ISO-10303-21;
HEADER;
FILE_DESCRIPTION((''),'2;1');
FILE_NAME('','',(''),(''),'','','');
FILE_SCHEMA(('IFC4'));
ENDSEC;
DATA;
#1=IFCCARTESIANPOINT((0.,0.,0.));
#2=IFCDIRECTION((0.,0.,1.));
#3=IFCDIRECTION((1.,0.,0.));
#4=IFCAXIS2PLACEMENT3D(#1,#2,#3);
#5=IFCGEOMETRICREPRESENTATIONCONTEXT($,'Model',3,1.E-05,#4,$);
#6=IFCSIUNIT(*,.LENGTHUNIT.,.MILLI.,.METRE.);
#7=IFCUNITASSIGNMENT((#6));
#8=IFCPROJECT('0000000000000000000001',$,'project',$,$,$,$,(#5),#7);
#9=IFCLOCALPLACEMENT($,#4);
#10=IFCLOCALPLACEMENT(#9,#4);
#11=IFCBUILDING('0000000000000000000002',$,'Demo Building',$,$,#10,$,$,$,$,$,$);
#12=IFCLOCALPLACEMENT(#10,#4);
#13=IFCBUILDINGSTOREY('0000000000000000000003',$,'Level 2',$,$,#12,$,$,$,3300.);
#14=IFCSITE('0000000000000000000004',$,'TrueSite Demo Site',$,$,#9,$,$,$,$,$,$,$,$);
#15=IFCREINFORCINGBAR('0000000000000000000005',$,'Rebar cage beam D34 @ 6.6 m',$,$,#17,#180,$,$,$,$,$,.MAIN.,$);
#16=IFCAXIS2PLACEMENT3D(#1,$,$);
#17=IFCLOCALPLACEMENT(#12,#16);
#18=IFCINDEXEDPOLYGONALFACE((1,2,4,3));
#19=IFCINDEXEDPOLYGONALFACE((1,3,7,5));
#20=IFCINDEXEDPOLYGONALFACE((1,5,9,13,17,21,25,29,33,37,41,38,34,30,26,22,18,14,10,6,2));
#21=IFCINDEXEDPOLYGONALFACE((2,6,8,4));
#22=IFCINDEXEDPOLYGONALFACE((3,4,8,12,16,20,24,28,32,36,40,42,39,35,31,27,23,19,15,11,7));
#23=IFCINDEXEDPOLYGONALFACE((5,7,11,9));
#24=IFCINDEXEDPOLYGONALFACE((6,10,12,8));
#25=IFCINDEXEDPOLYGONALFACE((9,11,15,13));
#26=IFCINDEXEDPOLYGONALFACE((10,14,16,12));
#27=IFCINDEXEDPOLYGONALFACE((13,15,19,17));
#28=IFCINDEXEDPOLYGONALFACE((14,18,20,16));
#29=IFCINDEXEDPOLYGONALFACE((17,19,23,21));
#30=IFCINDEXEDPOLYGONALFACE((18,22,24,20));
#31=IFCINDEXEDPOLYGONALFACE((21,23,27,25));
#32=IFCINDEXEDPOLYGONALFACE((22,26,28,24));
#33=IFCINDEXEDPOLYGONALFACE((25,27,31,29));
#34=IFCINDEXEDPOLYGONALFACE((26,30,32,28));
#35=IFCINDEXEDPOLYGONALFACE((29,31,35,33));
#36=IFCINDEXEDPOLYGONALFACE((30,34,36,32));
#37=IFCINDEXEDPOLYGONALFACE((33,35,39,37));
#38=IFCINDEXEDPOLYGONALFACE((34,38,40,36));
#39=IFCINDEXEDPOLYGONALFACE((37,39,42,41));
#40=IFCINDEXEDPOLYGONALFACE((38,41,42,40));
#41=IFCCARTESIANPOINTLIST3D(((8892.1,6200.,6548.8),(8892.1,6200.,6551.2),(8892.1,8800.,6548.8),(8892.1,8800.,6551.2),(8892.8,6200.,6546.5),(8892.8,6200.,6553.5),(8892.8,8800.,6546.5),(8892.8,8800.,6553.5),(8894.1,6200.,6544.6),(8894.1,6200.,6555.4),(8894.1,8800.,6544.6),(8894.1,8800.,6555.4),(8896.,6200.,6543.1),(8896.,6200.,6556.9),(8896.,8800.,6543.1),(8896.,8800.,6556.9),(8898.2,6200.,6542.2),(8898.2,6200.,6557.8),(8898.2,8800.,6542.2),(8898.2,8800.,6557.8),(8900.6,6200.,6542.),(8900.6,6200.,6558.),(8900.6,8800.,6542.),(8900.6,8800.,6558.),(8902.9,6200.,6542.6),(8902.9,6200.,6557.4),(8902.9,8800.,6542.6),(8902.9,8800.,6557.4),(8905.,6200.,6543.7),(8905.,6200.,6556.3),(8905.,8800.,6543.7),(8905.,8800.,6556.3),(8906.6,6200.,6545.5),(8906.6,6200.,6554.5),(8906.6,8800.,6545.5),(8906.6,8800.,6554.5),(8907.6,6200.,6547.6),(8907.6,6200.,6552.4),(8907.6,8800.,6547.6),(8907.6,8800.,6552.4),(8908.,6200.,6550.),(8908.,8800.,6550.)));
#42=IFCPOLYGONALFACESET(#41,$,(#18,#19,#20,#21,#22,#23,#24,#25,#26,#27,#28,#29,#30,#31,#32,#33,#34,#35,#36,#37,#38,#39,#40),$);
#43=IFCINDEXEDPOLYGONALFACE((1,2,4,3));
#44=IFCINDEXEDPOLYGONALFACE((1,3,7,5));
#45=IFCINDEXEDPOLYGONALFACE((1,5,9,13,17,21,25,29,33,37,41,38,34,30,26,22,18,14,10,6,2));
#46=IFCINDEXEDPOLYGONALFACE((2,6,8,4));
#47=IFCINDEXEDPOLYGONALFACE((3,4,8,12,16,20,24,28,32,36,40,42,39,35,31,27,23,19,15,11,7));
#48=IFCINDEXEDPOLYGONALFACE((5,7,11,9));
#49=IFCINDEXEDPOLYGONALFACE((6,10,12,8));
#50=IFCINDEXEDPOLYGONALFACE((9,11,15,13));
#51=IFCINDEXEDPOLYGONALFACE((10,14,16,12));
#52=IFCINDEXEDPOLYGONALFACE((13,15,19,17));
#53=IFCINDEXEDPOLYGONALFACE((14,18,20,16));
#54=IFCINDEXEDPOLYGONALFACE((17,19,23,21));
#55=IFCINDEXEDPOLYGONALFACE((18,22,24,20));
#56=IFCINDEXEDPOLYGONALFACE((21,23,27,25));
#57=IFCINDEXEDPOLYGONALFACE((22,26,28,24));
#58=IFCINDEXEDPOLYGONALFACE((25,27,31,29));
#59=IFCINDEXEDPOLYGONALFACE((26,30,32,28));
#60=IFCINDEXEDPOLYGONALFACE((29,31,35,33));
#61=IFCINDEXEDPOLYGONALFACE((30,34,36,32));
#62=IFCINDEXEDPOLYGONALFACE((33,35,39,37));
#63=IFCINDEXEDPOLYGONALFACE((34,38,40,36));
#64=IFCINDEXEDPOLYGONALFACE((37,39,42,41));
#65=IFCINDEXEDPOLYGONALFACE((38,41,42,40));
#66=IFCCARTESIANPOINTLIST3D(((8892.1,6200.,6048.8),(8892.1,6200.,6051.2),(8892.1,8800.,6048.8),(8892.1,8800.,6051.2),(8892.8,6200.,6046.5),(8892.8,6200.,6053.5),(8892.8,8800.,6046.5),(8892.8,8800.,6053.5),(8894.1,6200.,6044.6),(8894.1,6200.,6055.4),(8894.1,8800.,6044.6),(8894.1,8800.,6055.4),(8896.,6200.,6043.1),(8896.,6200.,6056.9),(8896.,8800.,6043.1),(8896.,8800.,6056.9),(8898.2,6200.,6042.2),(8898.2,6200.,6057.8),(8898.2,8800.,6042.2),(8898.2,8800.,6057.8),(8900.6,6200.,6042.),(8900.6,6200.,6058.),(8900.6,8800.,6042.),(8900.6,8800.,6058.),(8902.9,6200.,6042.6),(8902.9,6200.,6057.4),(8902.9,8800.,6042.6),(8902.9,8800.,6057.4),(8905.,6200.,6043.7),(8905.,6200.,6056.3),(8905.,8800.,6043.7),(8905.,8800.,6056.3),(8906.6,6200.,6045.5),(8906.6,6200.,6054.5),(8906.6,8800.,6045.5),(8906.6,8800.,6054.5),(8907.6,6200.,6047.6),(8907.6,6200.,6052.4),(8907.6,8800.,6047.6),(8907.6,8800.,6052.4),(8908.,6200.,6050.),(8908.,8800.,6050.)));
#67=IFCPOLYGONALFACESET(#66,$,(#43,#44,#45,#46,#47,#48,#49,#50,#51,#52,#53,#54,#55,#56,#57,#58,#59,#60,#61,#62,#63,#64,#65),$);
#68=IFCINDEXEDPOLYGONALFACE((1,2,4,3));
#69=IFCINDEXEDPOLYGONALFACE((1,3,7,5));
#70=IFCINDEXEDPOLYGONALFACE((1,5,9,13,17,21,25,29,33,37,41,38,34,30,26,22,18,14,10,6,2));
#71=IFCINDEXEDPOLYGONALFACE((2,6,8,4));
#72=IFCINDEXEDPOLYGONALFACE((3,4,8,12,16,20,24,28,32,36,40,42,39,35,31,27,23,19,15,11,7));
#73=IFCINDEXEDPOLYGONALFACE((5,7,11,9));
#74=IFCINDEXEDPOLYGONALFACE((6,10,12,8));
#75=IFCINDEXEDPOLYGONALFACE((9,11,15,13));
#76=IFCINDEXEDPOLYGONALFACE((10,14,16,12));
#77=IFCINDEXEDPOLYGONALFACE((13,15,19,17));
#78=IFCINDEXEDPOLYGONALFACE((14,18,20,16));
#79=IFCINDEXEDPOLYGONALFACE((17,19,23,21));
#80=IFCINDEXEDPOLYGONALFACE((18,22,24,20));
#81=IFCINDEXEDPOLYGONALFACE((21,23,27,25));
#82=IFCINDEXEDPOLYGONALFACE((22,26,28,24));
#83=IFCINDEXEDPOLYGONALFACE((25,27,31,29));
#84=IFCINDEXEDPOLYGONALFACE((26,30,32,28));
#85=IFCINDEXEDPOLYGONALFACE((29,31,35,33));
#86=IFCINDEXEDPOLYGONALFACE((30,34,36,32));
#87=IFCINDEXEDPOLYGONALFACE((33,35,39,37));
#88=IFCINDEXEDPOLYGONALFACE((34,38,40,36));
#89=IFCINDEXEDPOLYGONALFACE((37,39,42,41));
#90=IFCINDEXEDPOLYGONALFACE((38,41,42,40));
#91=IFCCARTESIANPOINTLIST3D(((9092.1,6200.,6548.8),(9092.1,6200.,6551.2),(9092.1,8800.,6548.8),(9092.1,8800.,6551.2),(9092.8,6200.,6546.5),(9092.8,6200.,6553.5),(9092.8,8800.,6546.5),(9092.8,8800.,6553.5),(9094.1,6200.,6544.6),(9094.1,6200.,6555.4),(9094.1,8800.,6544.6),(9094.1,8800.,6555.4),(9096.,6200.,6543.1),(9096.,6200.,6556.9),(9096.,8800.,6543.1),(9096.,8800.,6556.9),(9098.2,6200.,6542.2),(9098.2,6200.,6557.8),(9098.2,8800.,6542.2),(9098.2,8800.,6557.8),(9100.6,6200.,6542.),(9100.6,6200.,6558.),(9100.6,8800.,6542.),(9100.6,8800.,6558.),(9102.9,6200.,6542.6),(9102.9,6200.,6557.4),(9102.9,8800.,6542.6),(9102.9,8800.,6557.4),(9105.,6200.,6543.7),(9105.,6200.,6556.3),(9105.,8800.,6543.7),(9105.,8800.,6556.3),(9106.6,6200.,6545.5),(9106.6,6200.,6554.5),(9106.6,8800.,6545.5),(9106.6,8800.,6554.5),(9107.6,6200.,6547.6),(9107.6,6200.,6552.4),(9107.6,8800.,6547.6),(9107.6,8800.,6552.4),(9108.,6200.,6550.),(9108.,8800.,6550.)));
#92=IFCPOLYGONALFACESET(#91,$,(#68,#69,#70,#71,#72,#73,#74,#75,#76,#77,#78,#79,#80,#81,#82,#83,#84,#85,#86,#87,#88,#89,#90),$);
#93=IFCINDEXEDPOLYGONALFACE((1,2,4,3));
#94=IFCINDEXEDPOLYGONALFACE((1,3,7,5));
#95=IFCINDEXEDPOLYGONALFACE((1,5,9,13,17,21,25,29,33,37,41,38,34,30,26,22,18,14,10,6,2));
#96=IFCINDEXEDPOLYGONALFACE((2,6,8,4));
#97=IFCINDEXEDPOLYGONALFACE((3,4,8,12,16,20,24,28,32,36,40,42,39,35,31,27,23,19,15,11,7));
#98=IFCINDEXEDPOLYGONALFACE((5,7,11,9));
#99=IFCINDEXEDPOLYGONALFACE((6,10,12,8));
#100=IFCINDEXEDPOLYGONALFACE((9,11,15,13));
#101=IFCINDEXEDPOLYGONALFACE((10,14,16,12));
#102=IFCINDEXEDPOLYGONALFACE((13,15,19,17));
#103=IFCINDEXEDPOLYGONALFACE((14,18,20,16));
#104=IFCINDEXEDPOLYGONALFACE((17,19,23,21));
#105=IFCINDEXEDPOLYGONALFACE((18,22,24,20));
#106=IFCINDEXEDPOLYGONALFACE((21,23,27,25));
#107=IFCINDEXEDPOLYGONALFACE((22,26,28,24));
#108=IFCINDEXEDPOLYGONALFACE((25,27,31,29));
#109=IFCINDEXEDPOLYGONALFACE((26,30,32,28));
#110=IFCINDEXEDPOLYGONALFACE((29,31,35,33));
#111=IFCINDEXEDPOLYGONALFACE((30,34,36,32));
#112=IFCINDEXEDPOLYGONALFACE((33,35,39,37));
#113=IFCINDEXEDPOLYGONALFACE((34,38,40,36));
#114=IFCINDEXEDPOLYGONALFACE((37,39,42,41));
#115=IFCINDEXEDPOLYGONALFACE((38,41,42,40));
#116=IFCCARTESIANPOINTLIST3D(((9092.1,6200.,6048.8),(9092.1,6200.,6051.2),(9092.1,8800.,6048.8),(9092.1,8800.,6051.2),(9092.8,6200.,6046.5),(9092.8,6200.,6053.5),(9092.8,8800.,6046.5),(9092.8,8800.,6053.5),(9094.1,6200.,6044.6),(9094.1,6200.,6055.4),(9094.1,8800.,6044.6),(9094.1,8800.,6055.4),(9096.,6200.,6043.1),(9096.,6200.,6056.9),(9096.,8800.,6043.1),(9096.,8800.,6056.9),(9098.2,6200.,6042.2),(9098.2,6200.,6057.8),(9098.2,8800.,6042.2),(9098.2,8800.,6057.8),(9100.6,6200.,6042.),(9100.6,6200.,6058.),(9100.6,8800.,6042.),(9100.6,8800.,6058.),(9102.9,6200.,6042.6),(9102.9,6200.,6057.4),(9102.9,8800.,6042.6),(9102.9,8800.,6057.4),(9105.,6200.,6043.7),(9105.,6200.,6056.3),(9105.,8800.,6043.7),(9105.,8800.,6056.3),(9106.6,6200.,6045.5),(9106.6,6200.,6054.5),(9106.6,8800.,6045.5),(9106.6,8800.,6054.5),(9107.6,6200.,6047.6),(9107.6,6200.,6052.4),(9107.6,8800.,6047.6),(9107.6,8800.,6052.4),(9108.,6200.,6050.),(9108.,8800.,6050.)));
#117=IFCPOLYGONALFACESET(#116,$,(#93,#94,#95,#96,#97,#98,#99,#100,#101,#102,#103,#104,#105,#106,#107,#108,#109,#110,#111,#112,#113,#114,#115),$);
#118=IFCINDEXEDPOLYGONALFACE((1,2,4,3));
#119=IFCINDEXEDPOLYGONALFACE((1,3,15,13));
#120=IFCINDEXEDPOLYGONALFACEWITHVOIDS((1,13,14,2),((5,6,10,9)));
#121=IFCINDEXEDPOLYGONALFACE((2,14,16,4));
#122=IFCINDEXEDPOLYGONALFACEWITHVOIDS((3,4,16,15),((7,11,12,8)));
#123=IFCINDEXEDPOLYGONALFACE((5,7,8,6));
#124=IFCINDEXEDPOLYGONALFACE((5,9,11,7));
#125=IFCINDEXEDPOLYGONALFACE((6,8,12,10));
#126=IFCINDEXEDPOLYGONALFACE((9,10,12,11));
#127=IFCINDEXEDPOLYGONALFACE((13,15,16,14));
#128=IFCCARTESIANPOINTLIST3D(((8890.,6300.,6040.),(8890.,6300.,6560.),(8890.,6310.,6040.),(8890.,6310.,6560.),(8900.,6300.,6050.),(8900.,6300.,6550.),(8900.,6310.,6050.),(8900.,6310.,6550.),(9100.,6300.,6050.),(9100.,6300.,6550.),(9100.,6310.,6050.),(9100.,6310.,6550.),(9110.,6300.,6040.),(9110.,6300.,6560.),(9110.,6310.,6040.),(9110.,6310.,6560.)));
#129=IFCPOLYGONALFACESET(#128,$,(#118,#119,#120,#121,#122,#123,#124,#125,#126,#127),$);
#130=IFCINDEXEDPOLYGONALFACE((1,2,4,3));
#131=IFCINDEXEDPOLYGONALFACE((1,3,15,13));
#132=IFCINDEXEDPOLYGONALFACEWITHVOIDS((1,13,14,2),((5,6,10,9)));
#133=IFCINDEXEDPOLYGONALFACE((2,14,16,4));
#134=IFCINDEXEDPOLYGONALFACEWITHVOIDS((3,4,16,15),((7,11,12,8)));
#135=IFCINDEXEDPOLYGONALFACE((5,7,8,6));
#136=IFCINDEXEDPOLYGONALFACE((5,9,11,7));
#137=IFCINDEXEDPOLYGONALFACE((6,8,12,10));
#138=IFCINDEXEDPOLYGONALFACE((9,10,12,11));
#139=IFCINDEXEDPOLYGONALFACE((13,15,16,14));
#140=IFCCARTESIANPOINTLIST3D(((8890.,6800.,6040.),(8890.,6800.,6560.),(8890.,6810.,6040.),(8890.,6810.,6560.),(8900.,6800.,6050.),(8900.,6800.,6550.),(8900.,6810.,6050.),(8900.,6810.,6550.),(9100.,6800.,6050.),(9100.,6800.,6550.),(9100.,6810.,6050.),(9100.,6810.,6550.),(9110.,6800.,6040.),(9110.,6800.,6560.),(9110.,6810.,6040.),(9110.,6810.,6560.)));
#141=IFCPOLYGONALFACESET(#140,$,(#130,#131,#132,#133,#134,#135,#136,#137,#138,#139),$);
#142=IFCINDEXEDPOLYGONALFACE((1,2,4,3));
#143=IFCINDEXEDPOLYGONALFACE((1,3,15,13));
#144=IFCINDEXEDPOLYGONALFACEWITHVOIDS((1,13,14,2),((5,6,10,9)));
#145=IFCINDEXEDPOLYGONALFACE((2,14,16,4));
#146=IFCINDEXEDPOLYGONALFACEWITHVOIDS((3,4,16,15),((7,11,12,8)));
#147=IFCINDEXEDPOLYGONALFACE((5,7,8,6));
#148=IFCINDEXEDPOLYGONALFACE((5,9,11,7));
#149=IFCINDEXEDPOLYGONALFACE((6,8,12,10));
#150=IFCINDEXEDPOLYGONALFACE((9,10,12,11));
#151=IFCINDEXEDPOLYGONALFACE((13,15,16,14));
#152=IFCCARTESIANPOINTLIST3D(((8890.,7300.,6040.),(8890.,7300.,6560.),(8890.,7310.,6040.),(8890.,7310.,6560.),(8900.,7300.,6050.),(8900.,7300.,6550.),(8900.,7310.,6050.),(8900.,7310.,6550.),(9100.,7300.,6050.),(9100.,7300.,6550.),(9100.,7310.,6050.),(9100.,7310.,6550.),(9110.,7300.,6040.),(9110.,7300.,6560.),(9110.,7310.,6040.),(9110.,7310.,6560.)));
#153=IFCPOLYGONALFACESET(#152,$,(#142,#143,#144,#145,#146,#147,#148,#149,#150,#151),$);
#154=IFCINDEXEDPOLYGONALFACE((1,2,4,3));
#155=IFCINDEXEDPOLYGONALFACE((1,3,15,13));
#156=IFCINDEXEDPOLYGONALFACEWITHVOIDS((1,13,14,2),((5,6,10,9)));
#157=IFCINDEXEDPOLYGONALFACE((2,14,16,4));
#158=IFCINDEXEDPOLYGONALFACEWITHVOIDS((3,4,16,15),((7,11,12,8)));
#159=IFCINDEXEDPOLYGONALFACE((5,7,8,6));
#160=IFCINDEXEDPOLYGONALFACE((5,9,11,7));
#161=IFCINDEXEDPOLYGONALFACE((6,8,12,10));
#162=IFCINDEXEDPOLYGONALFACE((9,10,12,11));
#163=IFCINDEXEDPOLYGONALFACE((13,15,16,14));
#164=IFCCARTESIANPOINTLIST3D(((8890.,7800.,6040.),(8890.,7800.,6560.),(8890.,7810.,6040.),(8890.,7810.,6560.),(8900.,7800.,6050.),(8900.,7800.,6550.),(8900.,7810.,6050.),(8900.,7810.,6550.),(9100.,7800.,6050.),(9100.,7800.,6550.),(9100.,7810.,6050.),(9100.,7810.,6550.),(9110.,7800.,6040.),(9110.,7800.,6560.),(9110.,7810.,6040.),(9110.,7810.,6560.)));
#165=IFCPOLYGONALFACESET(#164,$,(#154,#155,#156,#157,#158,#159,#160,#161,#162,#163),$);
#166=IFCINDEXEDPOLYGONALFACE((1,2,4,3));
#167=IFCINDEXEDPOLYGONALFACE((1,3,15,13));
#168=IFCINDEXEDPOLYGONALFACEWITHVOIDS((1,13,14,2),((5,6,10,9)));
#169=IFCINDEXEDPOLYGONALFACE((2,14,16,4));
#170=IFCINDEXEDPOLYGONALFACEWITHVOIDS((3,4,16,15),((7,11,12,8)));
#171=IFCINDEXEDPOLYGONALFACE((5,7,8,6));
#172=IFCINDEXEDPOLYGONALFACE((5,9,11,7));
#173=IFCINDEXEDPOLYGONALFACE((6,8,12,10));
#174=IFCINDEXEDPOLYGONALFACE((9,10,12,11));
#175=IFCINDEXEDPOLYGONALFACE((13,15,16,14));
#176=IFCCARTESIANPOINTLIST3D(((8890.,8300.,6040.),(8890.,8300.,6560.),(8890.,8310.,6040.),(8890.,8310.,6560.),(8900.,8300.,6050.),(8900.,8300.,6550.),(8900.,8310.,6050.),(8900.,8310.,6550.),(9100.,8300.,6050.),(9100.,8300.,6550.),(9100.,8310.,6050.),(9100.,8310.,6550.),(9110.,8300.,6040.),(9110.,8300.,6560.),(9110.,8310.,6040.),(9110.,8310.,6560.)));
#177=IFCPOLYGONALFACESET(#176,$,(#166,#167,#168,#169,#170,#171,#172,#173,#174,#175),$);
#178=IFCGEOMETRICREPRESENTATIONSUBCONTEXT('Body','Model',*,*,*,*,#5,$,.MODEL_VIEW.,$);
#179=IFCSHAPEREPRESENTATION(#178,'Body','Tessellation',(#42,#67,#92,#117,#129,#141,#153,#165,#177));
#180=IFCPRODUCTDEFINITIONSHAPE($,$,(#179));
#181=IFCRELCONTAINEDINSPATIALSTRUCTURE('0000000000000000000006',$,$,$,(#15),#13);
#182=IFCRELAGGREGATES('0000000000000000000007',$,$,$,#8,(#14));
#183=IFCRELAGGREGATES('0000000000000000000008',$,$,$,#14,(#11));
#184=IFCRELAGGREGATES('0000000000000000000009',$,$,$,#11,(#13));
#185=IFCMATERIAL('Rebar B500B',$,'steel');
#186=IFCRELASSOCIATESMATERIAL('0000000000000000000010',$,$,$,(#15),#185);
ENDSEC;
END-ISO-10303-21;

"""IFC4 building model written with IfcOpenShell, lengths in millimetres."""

from ifc_helpers import new_model, si_unit, frame, origin_with_axes, place, context, subcontext, project, spatial, hollow_rectangle, circle, extrude, material, element, save


model = new_model("IFC4")

# Units and contexts
model_context = context("Model", 3, precision=1e-05, world=origin_with_axes())
body_context = subcontext(model_context, "Body", "Model", "MODEL_VIEW")
ifc_project = project(units=[si_unit("LENGTHUNIT", "METRE", prefix="MILLI")], contexts=[model_context])

# Site, building, storey
site_placement = place(None, origin_with_axes())
site = spatial("IfcSite", under=ifc_project, at=site_placement, Name="TrueSite Demo Site")
building_placement = place(site_placement, origin_with_axes())
building = spatial("IfcBuilding", under=site, at=building_placement, Name="Demo Building")
storey_placement = place(building_placement, origin_with_axes())
storey = spatial("IfcBuildingStorey", under=building, at=storey_placement, Name="Level 2", Elevation=3300.0)

# Reinforcing bar
ifc_material_1 = material(Name="Rebar B500B", Category="steel")
for number, where, z_axis, x_axis, name in (
    (1, (9000.0, 6200.0, 6300.0), (0.0, 1.0, 0.0), (1.0, 0.0, 0.0), "Rebar cage beam D34 @ 6.6 m"),
):
    element("IfcReinforcingBar", number, at=place(storey_placement, frame(where, z_axis=z_axis, x_axis=x_axis)), inside=storey, material=ifc_material_1, Name=name, PredefinedType="MAIN", context=body_context, shape_type="SweptSolid", body=[
        extrude(circle(Radius=8.0), frame((-100.0, -250.0, 0.0)), (0.0, 0.0, 1.0), 2600.0),
        extrude(circle(Radius=8.0), frame((-100.0, 250.0, 0.0)), (0.0, 0.0, 1.0), 2600.0),
        extrude(circle(Radius=8.0), frame((100.0, -250.0, 0.0)), (0.0, 0.0, 1.0), 2600.0),
        extrude(circle(Radius=8.0), frame((100.0, 250.0, 0.0)), (0.0, 0.0, 1.0), 2600.0),
        extrude(hollow_rectangle(XDim=220.0, YDim=520.0, WallThickness=10.0), frame((0.0, 0.0, 100.0)), (0.0, 0.0, 1.0), 10.0),
        extrude(hollow_rectangle(XDim=220.0, YDim=520.0, WallThickness=10.0), frame((0.0, 0.0, 600.0)), (0.0, 0.0, 1.0), 10.0),
        extrude(hollow_rectangle(XDim=220.0, YDim=520.0, WallThickness=10.0), frame((0.0, 0.0, 1100.0)), (0.0, 0.0, 1.0), 10.0),
        extrude(hollow_rectangle(XDim=220.0, YDim=520.0, WallThickness=10.0), frame((0.0, 0.0, 1600.0)), (0.0, 0.0, 1.0), 10.0),
        extrude(hollow_rectangle(XDim=220.0, YDim=520.0, WallThickness=10.0), frame((0.0, 0.0, 2100.0)), (0.0, 0.0, 1.0), 10.0),
    ])

save(model, "model.ifc")
